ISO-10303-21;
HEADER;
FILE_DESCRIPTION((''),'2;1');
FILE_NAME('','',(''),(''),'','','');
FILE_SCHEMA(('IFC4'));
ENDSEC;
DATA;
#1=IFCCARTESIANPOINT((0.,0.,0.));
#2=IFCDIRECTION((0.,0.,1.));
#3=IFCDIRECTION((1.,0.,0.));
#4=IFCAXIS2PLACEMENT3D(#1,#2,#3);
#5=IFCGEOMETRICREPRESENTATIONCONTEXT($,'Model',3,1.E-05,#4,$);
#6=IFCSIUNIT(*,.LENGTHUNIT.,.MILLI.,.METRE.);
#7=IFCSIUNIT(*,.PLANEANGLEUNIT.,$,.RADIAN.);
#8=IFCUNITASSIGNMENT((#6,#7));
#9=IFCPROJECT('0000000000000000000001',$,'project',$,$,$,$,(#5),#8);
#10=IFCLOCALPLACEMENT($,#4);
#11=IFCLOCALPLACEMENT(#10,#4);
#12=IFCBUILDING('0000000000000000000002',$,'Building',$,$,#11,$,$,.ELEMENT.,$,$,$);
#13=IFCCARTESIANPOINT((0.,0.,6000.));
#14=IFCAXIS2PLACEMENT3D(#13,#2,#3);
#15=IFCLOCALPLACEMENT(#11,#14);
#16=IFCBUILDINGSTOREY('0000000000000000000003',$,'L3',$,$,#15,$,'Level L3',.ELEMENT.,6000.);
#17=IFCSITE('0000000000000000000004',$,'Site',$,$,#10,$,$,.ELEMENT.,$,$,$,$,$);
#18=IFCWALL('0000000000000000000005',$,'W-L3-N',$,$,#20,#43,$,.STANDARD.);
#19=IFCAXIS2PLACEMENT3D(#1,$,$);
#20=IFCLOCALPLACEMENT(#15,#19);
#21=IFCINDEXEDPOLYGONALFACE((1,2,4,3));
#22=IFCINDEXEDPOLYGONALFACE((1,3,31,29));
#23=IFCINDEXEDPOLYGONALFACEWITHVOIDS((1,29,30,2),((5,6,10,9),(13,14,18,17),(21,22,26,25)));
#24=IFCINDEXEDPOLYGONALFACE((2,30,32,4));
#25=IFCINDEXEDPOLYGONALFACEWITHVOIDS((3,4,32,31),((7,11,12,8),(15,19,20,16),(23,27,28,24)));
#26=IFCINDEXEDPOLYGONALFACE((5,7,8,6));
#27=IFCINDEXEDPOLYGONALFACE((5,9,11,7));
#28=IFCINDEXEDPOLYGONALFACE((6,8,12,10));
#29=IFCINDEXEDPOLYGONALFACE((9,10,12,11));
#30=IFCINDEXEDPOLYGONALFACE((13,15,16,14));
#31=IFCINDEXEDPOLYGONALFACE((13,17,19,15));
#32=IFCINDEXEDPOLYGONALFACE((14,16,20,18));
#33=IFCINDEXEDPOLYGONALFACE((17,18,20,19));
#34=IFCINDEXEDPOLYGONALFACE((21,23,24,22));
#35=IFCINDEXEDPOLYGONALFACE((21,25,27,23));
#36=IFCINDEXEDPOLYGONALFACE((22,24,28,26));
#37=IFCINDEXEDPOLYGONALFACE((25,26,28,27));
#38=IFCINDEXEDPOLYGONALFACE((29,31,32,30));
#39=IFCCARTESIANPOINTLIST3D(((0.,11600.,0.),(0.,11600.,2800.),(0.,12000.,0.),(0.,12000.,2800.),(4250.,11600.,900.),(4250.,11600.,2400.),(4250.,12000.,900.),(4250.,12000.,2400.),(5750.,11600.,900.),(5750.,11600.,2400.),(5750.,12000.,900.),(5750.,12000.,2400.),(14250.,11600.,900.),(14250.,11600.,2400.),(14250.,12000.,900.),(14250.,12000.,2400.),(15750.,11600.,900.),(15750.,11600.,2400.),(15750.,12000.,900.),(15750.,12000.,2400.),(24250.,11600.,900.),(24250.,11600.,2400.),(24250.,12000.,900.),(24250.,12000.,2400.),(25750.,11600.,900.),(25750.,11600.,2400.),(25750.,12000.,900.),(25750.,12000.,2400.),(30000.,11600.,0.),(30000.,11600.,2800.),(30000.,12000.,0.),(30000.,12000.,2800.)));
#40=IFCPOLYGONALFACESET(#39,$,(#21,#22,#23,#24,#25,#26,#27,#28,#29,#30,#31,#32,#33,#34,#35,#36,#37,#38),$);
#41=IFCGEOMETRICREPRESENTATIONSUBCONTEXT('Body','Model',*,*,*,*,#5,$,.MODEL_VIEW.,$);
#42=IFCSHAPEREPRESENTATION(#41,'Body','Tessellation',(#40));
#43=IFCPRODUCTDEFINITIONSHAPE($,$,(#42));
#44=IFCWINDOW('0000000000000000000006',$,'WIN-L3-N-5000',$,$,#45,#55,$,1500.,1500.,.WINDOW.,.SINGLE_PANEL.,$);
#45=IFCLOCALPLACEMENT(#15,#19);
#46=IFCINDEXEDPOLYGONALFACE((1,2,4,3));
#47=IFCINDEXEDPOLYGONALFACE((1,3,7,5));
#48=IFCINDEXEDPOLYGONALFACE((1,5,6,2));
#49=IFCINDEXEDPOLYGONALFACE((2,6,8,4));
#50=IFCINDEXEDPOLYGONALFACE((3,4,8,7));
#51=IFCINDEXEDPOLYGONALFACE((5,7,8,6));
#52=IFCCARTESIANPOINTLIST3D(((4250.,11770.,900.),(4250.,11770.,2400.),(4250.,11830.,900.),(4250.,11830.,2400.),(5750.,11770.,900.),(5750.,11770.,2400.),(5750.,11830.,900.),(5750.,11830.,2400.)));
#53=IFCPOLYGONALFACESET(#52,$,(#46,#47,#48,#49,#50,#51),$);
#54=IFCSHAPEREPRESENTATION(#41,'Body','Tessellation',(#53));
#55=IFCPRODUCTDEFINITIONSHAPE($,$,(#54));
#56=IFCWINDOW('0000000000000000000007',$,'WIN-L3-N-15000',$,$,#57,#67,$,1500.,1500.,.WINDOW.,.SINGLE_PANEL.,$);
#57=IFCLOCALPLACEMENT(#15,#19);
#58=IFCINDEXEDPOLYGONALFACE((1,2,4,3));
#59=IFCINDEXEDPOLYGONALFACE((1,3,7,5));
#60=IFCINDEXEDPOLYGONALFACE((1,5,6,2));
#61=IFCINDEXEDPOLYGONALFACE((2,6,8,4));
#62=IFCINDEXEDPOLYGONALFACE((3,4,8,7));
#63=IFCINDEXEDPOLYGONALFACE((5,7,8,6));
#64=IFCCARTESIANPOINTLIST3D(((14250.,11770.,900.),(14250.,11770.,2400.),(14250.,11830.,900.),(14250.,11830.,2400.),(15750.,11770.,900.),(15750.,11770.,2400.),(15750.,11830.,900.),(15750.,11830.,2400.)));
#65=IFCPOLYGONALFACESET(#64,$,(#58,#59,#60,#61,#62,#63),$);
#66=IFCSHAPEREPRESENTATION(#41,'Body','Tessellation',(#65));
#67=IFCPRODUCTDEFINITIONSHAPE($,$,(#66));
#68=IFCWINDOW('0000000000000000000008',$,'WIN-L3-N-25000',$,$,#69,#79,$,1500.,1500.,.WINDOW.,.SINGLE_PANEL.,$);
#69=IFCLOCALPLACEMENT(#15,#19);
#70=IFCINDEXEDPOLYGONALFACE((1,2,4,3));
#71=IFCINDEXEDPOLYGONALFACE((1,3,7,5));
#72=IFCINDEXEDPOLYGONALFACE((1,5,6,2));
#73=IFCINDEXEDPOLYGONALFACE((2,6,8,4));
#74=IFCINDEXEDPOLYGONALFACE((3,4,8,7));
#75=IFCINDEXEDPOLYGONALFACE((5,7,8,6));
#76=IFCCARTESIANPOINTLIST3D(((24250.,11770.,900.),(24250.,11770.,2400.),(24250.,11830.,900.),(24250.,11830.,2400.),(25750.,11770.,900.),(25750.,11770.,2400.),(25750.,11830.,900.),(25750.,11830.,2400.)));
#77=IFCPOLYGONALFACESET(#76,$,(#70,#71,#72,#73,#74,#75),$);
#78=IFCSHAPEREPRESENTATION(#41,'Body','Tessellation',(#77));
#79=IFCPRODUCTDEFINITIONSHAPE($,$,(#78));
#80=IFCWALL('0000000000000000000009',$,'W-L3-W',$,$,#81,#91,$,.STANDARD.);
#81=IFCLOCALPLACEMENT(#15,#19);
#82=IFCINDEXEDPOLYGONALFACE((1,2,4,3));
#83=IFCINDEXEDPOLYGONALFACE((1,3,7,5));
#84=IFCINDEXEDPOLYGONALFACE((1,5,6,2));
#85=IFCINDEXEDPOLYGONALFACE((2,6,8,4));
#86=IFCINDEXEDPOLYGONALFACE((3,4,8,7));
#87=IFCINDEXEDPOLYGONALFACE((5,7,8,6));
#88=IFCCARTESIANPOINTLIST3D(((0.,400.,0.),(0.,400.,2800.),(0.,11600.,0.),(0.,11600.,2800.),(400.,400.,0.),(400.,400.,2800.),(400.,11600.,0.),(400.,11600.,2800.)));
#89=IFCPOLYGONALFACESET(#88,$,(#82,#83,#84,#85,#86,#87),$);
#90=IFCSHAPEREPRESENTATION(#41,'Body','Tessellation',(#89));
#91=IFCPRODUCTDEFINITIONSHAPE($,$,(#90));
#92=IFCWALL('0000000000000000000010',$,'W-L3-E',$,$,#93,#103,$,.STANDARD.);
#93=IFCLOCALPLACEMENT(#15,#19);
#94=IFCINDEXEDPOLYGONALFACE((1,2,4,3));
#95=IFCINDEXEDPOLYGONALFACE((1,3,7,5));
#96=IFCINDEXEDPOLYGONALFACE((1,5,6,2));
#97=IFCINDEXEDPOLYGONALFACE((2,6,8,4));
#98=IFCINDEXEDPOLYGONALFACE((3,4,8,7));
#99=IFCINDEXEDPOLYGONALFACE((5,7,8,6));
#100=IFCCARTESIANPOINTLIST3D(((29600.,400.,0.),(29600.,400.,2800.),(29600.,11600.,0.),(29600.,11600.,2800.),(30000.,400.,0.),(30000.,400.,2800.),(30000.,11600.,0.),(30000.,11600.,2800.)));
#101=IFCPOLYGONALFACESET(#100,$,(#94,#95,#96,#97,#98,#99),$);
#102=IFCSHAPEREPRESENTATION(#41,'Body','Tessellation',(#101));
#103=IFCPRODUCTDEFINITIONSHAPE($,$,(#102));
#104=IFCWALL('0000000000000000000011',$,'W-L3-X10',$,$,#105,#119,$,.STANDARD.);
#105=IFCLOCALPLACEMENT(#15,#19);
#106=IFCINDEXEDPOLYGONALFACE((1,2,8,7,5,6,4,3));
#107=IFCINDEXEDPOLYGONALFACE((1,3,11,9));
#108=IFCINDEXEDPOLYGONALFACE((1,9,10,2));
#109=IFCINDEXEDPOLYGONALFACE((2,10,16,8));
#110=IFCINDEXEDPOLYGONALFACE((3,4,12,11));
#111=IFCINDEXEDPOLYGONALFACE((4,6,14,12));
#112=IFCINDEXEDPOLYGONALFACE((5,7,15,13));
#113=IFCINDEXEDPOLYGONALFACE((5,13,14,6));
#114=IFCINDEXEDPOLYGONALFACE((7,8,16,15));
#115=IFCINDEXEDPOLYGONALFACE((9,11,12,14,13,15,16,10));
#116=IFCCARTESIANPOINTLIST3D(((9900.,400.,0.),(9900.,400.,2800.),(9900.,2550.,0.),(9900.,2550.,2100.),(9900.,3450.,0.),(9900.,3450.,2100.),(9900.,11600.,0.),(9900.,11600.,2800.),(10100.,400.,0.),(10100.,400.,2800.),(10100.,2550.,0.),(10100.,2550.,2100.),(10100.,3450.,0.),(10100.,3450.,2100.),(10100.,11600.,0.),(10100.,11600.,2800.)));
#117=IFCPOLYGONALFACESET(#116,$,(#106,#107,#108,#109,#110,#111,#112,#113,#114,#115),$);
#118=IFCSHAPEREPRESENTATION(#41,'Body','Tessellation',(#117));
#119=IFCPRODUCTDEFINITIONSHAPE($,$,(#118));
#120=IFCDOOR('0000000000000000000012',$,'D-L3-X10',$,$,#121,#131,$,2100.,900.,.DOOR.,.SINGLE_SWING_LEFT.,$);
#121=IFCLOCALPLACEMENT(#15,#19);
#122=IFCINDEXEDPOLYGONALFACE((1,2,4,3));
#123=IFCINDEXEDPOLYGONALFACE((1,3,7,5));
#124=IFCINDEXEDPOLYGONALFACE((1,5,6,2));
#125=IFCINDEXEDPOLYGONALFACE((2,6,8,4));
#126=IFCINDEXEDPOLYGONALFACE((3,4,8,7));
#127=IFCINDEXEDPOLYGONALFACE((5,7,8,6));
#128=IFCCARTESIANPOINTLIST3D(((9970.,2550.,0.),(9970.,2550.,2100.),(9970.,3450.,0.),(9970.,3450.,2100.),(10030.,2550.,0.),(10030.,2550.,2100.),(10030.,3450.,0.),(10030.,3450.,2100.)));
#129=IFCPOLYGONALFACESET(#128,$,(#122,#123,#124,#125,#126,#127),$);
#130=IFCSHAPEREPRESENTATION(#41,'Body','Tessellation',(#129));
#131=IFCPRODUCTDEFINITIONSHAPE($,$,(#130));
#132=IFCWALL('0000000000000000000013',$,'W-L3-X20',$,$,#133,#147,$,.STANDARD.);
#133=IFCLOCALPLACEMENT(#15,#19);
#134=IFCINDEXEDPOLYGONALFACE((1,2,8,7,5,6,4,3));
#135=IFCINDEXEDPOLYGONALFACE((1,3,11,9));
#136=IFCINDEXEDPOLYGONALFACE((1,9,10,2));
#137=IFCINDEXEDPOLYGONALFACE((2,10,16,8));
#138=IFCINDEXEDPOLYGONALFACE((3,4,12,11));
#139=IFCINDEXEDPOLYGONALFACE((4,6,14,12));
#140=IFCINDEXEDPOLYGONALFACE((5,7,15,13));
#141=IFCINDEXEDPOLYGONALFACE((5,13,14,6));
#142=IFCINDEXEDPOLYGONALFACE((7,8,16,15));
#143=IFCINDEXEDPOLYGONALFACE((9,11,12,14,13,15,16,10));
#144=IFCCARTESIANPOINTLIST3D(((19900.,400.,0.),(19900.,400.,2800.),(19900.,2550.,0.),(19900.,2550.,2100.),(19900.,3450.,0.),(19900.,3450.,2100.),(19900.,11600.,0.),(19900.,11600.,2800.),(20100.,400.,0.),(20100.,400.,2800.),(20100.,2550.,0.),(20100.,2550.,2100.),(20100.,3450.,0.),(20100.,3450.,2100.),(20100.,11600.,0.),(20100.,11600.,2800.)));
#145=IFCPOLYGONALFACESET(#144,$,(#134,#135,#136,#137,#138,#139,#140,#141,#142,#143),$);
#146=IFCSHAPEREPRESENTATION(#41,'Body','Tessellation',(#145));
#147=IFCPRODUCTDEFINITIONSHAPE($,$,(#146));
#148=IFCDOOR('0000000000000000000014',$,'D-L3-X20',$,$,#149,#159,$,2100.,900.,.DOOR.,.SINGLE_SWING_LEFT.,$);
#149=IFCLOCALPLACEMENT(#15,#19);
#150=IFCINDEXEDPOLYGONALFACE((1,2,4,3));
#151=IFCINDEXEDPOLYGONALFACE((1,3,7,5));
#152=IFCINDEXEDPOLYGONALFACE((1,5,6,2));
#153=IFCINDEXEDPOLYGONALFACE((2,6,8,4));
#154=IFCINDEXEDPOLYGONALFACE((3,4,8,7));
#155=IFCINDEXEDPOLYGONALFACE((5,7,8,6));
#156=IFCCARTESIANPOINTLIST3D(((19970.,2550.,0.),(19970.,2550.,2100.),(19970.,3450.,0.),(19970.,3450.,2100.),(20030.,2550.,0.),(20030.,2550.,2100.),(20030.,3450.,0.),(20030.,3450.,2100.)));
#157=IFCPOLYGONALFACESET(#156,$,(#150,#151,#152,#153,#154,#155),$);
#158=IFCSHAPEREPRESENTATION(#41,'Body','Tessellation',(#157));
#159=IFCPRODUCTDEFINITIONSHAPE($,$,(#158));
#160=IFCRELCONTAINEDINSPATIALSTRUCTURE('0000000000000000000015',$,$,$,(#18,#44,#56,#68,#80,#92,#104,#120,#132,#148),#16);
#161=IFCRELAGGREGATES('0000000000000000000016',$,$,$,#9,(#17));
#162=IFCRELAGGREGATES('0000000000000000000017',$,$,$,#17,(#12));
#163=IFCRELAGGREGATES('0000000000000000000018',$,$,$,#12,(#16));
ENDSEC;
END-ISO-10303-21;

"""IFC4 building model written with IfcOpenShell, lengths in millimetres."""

from ifc_helpers import new_model, si_unit, frame, origin_with_axes, origin_2d, place, context, subcontext, project, spatial, rectangle, extrude, element, fill, save


model = new_model("IFC4")

# Units and contexts
model_context = context("Model", 3, precision=1e-05, world=origin_with_axes())
body_context = subcontext(model_context, "Body", "Model", "MODEL_VIEW")
ifc_project = project(units=[si_unit("LENGTHUNIT", "METRE", prefix="MILLI"), si_unit("PLANEANGLEUNIT", "RADIAN")], contexts=[model_context])

# Site, building, storey
site_placement = place(None, origin_with_axes())
site = spatial("IfcSite", under=ifc_project, at=site_placement, Name="Site", CompositionType="ELEMENT")
building_placement = place(site_placement, origin_with_axes())
building = spatial("IfcBuilding", under=site, at=building_placement, Name="Building", CompositionType="ELEMENT")
storey_placement = place(building_placement, frame((0.0, 0.0, 6000.0), z_axis=(0.0, 0.0, 1.0), x_axis=(1.0, 0.0, 0.0)))
storey = spatial("IfcBuildingStorey", under=building, at=storey_placement, Name="L3", LongName="Level L3", CompositionType="ELEMENT", Elevation=6000.0)

# Wall, openings, windows
wall_1_placement = place(storey_placement, frame((15000.0, 11800.0, 0.0), z_axis=(0.0, 0.0, 1.0), x_axis=(1.0, 0.0, 0.0)))
wall_1 = element("IfcWall", 1, at=wall_1_placement, inside=storey, Name="W-L3-N", PredefinedType="STANDARD", context=body_context, shape_type="SweptSolid", body=[
    extrude(rectangle(XDim=30000.0, YDim=400.0, at=origin_2d()), origin_with_axes(), (0.0, 0.0, 1.0), 2800.0),
])
opening_1_placement = place(wall_1_placement, frame((-10000.0, 0.0, 900.0), z_axis=(0.0, 0.0, 1.0), x_axis=(1.0, 0.0, 0.0)))
opening_1 = element("IfcOpeningElement", 2, at=opening_1_placement, cuts=wall_1, PredefinedType="OPENING", context=body_context, shape_type="SweptSolid", body=[
    extrude(rectangle(XDim=1500.0, YDim=500.0, at=origin_2d()), origin_with_axes(), (0.0, 0.0, 1.0), 1500.0),
])
opening_2_placement = place(wall_1_placement, frame((0.0, 0.0, 900.0), z_axis=(0.0, 0.0, 1.0), x_axis=(1.0, 0.0, 0.0)))
opening_2 = element("IfcOpeningElement", 3, at=opening_2_placement, cuts=wall_1, PredefinedType="OPENING", context=body_context, shape_type="SweptSolid", body=[
    extrude(rectangle(XDim=1500.0, YDim=500.0, at=origin_2d()), origin_with_axes(), (0.0, 0.0, 1.0), 1500.0),
])
opening_3_placement = place(wall_1_placement, frame((10000.0, 0.0, 900.0), z_axis=(0.0, 0.0, 1.0), x_axis=(1.0, 0.0, 0.0)))
opening_3 = element("IfcOpeningElement", 4, at=opening_3_placement, cuts=wall_1, PredefinedType="OPENING", context=body_context, shape_type="SweptSolid", body=[
    extrude(rectangle(XDim=1500.0, YDim=500.0, at=origin_2d()), origin_with_axes(), (0.0, 0.0, 1.0), 1500.0),
])
window_1_placement = place(wall_1_placement, frame((-10000.0, 0.0, 900.0), z_axis=(0.0, 0.0, 1.0), x_axis=(1.0, 0.0, 0.0)))
window_1 = element("IfcWindow", 5, at=window_1_placement, inside=storey, Name="WIN-L3-N-5000", OverallHeight=1500.0, OverallWidth=1500.0, PartitioningType="SINGLE_PANEL", PredefinedType="WINDOW", context=body_context, shape_type="SweptSolid", body=[
    extrude(rectangle(XDim=1500.0, YDim=60.0, at=origin_2d()), origin_with_axes(), (0.0, 0.0, 1.0), 1500.0),
])
fill(opening_1, window_1)
window_2_placement = place(wall_1_placement, frame((0.0, 0.0, 900.0), z_axis=(0.0, 0.0, 1.0), x_axis=(1.0, 0.0, 0.0)))
window_2 = element("IfcWindow", 6, at=window_2_placement, inside=storey, Name="WIN-L3-N-15000", OverallHeight=1500.0, OverallWidth=1500.0, PartitioningType="SINGLE_PANEL", PredefinedType="WINDOW", context=body_context, shape_type="SweptSolid", body=[
    extrude(rectangle(XDim=1500.0, YDim=60.0, at=origin_2d()), origin_with_axes(), (0.0, 0.0, 1.0), 1500.0),
])
fill(opening_2, window_2)
window_3_placement = place(wall_1_placement, frame((10000.0, 0.0, 900.0), z_axis=(0.0, 0.0, 1.0), x_axis=(1.0, 0.0, 0.0)))
window_3 = element("IfcWindow", 7, at=window_3_placement, inside=storey, Name="WIN-L3-N-25000", OverallHeight=1500.0, OverallWidth=1500.0, PartitioningType="SINGLE_PANEL", PredefinedType="WINDOW", context=body_context, shape_type="SweptSolid", body=[
    extrude(rectangle(XDim=1500.0, YDim=60.0, at=origin_2d()), origin_with_axes(), (0.0, 0.0, 1.0), 1500.0),
])
fill(opening_3, window_3)

# Walls
for number, where, z_axis, x_axis, name in (
    (8, (200.0, 6000.0, 0.0), (0.0, 0.0, 1.0), (1.0, 0.0, 0.0), "W-L3-W"),
    (9, (29800.0, 6000.0, 0.0), (0.0, 0.0, 1.0), (1.0, 0.0, 0.0), "W-L3-E"),
):
    element("IfcWall", number, at=place(storey_placement, frame(where, z_axis=z_axis, x_axis=x_axis)), inside=storey, Name=name, PredefinedType="STANDARD", context=body_context, shape_type="SweptSolid", body=[
        extrude(rectangle(XDim=400.0, YDim=11200.0, at=origin_2d()), origin_with_axes(), (0.0, 0.0, 1.0), 2800.0),
    ])

# Walls, openings, doors
wall_2_placement = place(storey_placement, frame((10000.0, 6000.0, 0.0), z_axis=(0.0, 0.0, 1.0), x_axis=(1.0, 0.0, 0.0)))
wall_2 = element("IfcWall", 10, at=wall_2_placement, inside=storey, Name="W-L3-X10", PredefinedType="STANDARD", context=body_context, shape_type="SweptSolid", body=[
    extrude(rectangle(XDim=200.0, YDim=11200.0, at=origin_2d()), origin_with_axes(), (0.0, 0.0, 1.0), 2800.0),
])
opening_4_placement = place(wall_2_placement, frame((0.0, -3000.0, 0.0), z_axis=(0.0, 0.0, 1.0), x_axis=(1.0, 0.0, 0.0)))
opening_4 = element("IfcOpeningElement", 11, at=opening_4_placement, cuts=wall_2, PredefinedType="OPENING", context=body_context, shape_type="SweptSolid", body=[
    extrude(rectangle(XDim=300.0, YDim=900.0, at=origin_2d()), origin_with_axes(), (0.0, 0.0, 1.0), 2100.0),
])
door_1_placement = place(wall_2_placement, frame((0.0, -3000.0, 0.0), z_axis=(0.0, 0.0, 1.0), x_axis=(1.0, 0.0, 0.0)))
door_1 = element("IfcDoor", 12, at=door_1_placement, inside=storey, Name="D-L3-X10", OperationType="SINGLE_SWING_LEFT", OverallHeight=2100.0, OverallWidth=900.0, PredefinedType="DOOR", context=body_context, shape_type="SweptSolid", body=[
    extrude(rectangle(XDim=60.0, YDim=900.0, at=origin_2d()), origin_with_axes(), (0.0, 0.0, 1.0), 2100.0),
])
fill(opening_4, door_1)
wall_3_placement = place(storey_placement, frame((20000.0, 6000.0, 0.0), z_axis=(0.0, 0.0, 1.0), x_axis=(1.0, 0.0, 0.0)))
wall_3 = element("IfcWall", 13, at=wall_3_placement, inside=storey, Name="W-L3-X20", PredefinedType="STANDARD", context=body_context, shape_type="SweptSolid", body=[
    extrude(rectangle(XDim=200.0, YDim=11200.0, at=origin_2d()), origin_with_axes(), (0.0, 0.0, 1.0), 2800.0),
])
opening_5_placement = place(wall_3_placement, frame((0.0, -3000.0, 0.0), z_axis=(0.0, 0.0, 1.0), x_axis=(1.0, 0.0, 0.0)))
opening_5 = element("IfcOpeningElement", 14, at=opening_5_placement, cuts=wall_3, PredefinedType="OPENING", context=body_context, shape_type="SweptSolid", body=[
    extrude(rectangle(XDim=300.0, YDim=900.0, at=origin_2d()), origin_with_axes(), (0.0, 0.0, 1.0), 2100.0),
])
door_2_placement = place(wall_3_placement, frame((0.0, -3000.0, 0.0), z_axis=(0.0, 0.0, 1.0), x_axis=(1.0, 0.0, 0.0)))
door_2 = element("IfcDoor", 15, at=door_2_placement, inside=storey, Name="D-L3-X20", OperationType="SINGLE_SWING_LEFT", OverallHeight=2100.0, OverallWidth=900.0, PredefinedType="DOOR", context=body_context, shape_type="SweptSolid", body=[
    extrude(rectangle(XDim=60.0, YDim=900.0, at=origin_2d()), origin_with_axes(), (0.0, 0.0, 1.0), 2100.0),
])
fill(opening_5, door_2)

save(model, "model.ifc")
